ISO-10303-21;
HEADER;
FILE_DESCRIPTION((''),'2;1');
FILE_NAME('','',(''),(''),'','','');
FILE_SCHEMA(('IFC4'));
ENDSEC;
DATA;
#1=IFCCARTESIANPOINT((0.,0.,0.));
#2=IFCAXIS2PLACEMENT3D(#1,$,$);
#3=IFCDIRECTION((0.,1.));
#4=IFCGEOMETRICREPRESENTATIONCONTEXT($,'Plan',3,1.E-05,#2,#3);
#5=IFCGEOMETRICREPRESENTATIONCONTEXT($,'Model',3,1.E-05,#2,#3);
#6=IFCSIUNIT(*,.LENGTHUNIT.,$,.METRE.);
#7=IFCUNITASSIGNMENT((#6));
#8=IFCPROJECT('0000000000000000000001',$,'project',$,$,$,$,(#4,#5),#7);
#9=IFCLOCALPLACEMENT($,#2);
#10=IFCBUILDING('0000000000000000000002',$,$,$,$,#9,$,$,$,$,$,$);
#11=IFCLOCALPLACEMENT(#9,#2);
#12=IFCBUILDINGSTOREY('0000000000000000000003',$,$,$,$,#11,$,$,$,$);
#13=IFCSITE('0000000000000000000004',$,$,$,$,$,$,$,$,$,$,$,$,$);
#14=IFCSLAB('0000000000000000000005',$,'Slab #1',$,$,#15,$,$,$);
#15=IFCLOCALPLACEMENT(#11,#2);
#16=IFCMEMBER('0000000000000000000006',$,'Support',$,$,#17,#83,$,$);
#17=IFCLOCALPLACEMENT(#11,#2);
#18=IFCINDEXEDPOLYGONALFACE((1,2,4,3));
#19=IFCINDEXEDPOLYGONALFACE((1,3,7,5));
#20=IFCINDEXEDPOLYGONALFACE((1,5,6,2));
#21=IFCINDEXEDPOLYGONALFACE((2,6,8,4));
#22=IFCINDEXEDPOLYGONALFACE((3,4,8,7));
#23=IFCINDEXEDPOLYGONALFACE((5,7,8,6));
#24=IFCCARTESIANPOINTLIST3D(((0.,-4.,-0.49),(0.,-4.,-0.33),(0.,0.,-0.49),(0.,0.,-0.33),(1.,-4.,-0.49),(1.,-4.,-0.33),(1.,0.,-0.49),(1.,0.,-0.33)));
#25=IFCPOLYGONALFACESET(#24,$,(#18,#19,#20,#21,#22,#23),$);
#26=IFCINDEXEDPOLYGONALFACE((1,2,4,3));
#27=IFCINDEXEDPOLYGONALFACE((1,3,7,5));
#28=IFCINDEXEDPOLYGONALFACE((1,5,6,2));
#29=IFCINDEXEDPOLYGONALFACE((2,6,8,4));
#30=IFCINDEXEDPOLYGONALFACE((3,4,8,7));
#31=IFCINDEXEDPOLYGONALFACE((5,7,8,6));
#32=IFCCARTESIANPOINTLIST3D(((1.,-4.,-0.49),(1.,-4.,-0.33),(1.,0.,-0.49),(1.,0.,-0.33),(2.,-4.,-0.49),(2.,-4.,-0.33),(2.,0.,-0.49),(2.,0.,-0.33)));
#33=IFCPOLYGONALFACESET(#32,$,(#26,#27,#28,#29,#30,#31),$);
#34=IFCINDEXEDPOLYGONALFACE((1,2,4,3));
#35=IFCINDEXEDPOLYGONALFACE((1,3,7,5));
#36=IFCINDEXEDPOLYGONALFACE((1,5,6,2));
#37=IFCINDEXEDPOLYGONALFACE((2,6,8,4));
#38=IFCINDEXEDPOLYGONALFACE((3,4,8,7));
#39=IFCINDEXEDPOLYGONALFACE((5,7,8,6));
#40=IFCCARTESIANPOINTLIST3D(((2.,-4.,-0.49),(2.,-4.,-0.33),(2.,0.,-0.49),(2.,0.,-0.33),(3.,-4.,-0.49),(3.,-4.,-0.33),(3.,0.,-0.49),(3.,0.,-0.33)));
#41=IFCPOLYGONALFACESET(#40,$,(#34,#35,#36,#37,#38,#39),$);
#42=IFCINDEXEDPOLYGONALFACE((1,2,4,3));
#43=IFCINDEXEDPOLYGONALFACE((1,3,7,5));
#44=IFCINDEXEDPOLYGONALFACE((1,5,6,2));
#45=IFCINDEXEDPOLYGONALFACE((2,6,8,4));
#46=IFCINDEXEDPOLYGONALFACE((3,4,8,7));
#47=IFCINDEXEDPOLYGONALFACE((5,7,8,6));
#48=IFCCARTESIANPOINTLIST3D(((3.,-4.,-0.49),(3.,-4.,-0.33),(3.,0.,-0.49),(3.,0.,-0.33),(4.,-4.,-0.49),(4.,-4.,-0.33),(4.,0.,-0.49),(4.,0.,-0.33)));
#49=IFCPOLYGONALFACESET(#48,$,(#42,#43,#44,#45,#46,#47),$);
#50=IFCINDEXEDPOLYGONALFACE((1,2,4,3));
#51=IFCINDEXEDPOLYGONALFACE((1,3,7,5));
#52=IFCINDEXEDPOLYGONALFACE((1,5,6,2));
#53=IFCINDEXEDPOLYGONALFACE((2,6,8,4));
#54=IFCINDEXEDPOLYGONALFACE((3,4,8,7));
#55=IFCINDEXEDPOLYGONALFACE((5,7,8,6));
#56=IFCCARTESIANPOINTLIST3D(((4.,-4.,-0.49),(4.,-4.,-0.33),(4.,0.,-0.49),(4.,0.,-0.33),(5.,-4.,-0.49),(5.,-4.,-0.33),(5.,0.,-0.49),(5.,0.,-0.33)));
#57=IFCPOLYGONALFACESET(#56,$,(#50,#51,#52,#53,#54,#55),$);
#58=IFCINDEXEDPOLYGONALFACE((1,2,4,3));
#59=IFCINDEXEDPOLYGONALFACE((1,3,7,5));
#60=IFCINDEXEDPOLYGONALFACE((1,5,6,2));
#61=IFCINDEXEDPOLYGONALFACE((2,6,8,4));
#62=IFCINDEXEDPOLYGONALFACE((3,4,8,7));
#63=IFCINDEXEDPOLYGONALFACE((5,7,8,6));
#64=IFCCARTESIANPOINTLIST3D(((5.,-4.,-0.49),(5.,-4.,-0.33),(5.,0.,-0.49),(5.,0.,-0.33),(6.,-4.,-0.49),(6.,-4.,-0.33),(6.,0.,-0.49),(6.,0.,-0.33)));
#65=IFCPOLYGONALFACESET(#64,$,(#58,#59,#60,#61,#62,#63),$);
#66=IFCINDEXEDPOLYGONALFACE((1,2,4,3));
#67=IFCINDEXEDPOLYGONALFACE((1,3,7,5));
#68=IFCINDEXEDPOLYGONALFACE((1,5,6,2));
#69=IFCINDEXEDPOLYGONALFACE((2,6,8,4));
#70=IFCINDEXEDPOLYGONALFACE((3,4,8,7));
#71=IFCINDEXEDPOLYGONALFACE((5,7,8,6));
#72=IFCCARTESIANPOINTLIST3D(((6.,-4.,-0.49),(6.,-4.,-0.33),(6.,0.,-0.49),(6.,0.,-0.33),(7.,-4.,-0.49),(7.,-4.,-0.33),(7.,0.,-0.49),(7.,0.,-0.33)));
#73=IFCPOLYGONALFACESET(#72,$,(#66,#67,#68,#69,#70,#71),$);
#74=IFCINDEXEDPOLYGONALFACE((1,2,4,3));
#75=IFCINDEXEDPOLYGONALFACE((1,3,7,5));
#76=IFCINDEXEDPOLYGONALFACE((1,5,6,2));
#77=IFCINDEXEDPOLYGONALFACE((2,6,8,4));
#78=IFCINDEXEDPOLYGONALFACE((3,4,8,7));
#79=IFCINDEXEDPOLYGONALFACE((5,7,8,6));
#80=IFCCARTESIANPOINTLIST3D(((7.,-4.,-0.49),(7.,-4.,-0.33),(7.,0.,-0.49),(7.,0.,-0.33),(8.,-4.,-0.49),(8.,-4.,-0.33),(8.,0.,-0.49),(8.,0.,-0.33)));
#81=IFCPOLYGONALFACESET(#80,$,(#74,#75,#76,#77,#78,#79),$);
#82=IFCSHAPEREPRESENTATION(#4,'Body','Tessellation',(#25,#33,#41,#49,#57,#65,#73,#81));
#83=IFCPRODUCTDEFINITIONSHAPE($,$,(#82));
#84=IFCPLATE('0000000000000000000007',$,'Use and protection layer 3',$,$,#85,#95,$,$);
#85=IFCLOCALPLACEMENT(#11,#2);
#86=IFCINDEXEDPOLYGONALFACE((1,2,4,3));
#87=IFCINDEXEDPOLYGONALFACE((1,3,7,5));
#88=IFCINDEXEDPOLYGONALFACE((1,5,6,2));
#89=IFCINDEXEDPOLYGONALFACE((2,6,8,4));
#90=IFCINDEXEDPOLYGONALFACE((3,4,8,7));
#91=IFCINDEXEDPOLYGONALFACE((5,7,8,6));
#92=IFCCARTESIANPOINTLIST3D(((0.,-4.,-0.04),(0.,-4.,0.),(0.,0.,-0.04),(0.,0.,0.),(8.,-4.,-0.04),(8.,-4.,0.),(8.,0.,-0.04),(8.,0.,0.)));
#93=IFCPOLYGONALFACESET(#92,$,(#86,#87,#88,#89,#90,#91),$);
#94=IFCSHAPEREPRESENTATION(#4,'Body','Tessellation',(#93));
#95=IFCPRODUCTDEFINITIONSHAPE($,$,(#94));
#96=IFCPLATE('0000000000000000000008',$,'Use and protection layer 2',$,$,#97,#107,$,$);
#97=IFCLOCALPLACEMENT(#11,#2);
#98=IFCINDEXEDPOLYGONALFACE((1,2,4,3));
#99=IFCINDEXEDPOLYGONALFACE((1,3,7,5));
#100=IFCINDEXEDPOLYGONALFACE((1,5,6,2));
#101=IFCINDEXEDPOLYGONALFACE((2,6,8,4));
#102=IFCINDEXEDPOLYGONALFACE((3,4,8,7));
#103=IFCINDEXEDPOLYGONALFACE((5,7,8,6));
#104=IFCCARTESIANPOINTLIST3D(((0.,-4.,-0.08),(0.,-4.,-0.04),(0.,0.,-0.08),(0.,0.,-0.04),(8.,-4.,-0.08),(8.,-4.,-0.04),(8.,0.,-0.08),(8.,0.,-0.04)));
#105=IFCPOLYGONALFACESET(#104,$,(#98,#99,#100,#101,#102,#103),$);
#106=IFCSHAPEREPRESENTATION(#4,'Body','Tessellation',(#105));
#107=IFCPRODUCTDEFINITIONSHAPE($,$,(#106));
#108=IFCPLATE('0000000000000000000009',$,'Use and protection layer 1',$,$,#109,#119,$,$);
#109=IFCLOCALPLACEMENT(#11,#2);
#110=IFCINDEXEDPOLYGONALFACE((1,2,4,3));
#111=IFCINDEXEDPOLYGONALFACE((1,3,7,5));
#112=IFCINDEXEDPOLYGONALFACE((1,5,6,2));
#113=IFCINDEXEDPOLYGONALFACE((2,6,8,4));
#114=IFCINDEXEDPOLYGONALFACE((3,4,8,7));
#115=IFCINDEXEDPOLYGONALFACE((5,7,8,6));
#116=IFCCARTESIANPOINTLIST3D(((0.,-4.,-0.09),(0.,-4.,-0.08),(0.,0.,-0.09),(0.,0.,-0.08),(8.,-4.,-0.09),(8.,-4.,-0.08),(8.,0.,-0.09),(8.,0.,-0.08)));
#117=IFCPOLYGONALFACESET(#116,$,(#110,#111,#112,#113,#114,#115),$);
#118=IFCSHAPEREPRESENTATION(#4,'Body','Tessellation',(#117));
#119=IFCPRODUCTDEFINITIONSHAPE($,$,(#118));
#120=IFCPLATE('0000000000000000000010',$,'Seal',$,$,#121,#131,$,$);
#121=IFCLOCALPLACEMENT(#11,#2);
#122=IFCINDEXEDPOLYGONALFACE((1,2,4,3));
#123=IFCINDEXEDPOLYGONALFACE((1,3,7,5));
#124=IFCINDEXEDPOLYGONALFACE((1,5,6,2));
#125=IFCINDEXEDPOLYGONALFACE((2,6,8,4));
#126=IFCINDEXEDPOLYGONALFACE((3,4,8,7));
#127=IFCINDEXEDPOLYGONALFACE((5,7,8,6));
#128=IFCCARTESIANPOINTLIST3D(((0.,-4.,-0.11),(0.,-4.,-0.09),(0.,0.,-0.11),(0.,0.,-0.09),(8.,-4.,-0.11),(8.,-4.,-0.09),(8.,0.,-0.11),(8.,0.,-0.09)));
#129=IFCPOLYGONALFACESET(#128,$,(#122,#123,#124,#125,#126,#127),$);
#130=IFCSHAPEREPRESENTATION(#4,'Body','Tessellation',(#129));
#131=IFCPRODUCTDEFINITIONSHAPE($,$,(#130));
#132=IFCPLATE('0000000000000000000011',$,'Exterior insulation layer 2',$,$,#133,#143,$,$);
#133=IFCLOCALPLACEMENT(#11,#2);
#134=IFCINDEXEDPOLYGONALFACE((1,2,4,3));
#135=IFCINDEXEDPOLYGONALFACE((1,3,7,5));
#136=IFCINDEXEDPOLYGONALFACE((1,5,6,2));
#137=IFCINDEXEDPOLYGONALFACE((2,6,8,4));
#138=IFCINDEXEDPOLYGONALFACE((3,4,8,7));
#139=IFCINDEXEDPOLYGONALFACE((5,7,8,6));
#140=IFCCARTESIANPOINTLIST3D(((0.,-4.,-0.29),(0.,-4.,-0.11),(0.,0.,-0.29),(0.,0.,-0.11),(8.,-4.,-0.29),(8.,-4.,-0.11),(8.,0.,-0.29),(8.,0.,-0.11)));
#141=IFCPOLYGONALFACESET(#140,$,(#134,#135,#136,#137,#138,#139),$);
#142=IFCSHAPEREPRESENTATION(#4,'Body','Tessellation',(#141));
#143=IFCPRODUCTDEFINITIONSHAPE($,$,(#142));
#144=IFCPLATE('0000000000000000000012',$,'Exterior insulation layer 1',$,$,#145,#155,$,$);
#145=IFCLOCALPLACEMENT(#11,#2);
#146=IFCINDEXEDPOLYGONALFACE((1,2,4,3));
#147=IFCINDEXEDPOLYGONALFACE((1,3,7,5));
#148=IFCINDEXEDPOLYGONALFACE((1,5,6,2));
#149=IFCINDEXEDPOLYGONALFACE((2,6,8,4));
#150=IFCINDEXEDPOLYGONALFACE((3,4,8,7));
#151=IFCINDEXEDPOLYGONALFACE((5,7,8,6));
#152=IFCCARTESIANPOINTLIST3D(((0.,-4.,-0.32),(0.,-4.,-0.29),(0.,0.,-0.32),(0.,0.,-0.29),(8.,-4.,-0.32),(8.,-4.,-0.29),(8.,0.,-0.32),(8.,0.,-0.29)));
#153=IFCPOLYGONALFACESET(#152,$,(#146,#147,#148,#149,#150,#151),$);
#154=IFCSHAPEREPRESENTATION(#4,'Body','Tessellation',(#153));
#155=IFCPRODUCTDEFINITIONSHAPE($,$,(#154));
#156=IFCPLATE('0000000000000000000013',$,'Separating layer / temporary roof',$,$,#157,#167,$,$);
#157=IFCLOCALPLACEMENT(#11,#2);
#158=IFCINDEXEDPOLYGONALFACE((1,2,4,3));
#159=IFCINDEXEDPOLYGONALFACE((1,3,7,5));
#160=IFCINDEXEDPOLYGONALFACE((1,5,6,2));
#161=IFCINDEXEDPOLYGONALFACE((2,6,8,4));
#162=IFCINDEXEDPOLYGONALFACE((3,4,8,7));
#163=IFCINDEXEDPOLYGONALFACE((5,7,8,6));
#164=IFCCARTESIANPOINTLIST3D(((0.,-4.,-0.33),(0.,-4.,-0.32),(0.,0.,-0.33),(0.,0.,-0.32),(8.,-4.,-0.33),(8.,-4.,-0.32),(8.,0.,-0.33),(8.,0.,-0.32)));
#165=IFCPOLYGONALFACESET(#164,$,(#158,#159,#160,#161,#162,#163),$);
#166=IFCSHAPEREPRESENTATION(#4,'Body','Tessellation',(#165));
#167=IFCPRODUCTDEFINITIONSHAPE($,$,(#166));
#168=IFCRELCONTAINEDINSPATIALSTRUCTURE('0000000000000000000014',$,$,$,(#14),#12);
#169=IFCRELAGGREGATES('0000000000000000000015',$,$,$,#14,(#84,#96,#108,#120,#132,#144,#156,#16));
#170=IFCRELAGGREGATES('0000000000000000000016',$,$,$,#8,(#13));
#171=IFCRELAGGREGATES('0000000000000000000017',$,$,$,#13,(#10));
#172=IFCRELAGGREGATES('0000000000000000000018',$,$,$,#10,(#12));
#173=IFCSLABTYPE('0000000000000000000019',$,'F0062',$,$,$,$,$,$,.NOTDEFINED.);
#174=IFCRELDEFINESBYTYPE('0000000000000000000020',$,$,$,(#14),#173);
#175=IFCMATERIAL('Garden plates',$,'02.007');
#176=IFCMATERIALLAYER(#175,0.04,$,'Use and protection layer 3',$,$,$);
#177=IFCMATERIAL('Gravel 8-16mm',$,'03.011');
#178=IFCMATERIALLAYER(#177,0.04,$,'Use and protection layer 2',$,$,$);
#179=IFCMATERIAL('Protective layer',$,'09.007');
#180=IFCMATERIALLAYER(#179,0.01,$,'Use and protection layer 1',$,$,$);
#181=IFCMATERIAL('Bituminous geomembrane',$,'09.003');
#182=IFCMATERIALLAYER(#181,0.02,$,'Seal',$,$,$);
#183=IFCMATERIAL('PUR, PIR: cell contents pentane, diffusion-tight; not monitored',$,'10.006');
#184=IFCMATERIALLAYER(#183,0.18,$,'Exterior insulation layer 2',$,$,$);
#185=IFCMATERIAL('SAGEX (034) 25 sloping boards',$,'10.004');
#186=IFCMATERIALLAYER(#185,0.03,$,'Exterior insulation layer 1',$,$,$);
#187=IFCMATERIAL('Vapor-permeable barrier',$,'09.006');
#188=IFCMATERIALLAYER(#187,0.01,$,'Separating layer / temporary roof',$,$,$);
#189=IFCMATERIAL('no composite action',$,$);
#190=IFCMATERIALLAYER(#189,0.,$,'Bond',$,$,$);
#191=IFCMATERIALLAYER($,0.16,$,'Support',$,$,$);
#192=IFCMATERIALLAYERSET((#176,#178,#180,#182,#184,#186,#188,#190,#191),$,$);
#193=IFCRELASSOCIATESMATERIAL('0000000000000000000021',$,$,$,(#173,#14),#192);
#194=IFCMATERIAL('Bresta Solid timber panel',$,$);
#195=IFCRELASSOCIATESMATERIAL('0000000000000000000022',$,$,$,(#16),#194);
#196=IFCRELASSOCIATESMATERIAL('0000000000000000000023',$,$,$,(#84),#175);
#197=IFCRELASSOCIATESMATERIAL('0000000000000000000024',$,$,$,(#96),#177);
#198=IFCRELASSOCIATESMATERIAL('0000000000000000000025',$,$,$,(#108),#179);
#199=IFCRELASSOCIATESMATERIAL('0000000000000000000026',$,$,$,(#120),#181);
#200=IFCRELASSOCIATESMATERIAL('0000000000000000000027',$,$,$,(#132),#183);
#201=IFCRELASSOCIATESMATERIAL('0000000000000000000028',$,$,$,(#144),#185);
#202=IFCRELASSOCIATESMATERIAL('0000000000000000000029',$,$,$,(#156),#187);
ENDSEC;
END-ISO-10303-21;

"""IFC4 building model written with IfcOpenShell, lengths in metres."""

from ifc_helpers import new_model, si_unit, direction, frame, frame_2d, origin, origin_with_axes, place, context, project, spatial, rectangle, extrude, material, layer, layer_set, type_object, element, aggregate, save


model = new_model("IFC4")

# Units and contexts
plan_context = context("Plan", 3, precision=1e-05, world=origin(), true_north=direction((0.0, 1.0)))
model_context = context("Model", 3, precision=1e-05, world=origin(), true_north=direction((0.0, 1.0)))
ifc_project = project(units=[si_unit("LENGTHUNIT", "METRE")], contexts=[plan_context, model_context])

# Site, building, storey
site = spatial("IfcSite", under=ifc_project)
building_placement = place(None, origin())
building = spatial("IfcBuilding", under=site, at=building_placement)
storey_placement = place(building_placement, origin())
storey = spatial("IfcBuildingStorey", under=building, at=storey_placement)

# Slab, member, plates
ifc_material_1 = material(Name="Garden plates", Category="02.007")
ifc_layer_1 = layer(ifc_material_1, 0.04, Name="Use and protection layer 3")
ifc_material_2 = material(Name="Gravel 8-16mm", Category="03.011")
ifc_layer_2 = layer(ifc_material_2, 0.04, Name="Use and protection layer 2")
ifc_material_3 = material(Name="Protective layer", Category="09.007")
ifc_layer_3 = layer(ifc_material_3, 0.01, Name="Use and protection layer 1")
ifc_material_4 = material(Name="Bituminous geomembrane", Category="09.003")
ifc_layer_4 = layer(ifc_material_4, 0.02, Name="Seal")
ifc_material_5 = material(Name="PUR, PIR: cell contents pentane, diffusion-tight; not monitored", Category="10.006")
ifc_layer_5 = layer(ifc_material_5, 0.18, Name="Exterior insulation layer 2")
ifc_material_6 = material(Name="SAGEX (034) 25 sloping boards", Category="10.004")
ifc_layer_6 = layer(ifc_material_6, 0.03, Name="Exterior insulation layer 1")
ifc_material_7 = material(Name="Vapor-permeable barrier", Category="09.006")
ifc_layer_7 = layer(ifc_material_7, 0.01, Name="Separating layer / temporary roof")
ifc_material_8 = material(Name="no composite action")
ifc_layer_8 = layer(ifc_material_8, 0.0, Name="Bond")
ifc_layer_9 = layer(None, 0.16, Name="Support")
ifc_layer_set = layer_set([ifc_layer_1, ifc_layer_2, ifc_layer_3, ifc_layer_4, ifc_layer_5, ifc_layer_6, ifc_layer_7, ifc_layer_8, ifc_layer_9])
slab_type = type_object("IfcSlabType", Name="F0062", PredefinedType="NOTDEFINED", material=ifc_layer_set)
slab_placement = place(None, frame((0.0, 0.0, 0.0), z_axis=(0.0, 0.0, -1.0), x_axis=(1.0, 0.0, 0.0)))
slab = element("IfcSlab", 1, at=slab_placement, inside=storey, type_object=slab_type, material=ifc_layer_set, Name="Slab #1")
ifc_material_9 = material(Name="Bresta Solid timber panel")
member_placement = place(slab_placement, origin())
member = element("IfcMember", 2, at=member_placement, material=ifc_material_9, Name="Support", context=plan_context, shape_type="SweptSolid", body=[
    extrude(rectangle(XDim=1.0, YDim=0.16, at=frame_2d((0.5, 0.08), x_axis=(1.0, 0.0))), frame((0.0, 4.0, 0.33), z_axis=(0.0, -1.0, 0.0), x_axis=(1.0, 0.0, 0.0)), (0.0, 0.0, 1.0), 4.0),
    extrude(rectangle(XDim=1.0, YDim=0.16, at=frame_2d((0.5, 0.08), x_axis=(1.0, 0.0))), frame((1.0, 4.0, 0.33), z_axis=(0.0, -1.0, 0.0), x_axis=(1.0, 0.0, 0.0)), (0.0, 0.0, 1.0), 4.0),
    extrude(rectangle(XDim=1.0, YDim=0.16, at=frame_2d((0.5, 0.08), x_axis=(1.0, 0.0))), frame((2.0, 4.0, 0.33), z_axis=(0.0, -1.0, 0.0), x_axis=(1.0, 0.0, 0.0)), (0.0, 0.0, 1.0), 4.0),
    extrude(rectangle(XDim=1.0, YDim=0.16, at=frame_2d((0.5, 0.08), x_axis=(1.0, 0.0))), frame((3.0, 4.0, 0.33), z_axis=(0.0, -1.0, 0.0), x_axis=(1.0, 0.0, 0.0)), (0.0, 0.0, 1.0), 4.0),
    extrude(rectangle(XDim=1.0, YDim=0.16, at=frame_2d((0.5, 0.08), x_axis=(1.0, 0.0))), frame((4.0, 4.0, 0.33), z_axis=(0.0, -1.0, 0.0), x_axis=(1.0, 0.0, 0.0)), (0.0, 0.0, 1.0), 4.0),
    extrude(rectangle(XDim=1.0, YDim=0.16, at=frame_2d((0.5, 0.08), x_axis=(1.0, 0.0))), frame((5.0, 4.0, 0.33), z_axis=(0.0, -1.0, 0.0), x_axis=(1.0, 0.0, 0.0)), (0.0, 0.0, 1.0), 4.0),
    extrude(rectangle(XDim=1.0, YDim=0.16, at=frame_2d((0.5, 0.08), x_axis=(1.0, 0.0))), frame((6.0, 4.0, 0.33), z_axis=(0.0, -1.0, 0.0), x_axis=(1.0, 0.0, 0.0)), (0.0, 0.0, 1.0), 4.0),
    extrude(rectangle(XDim=1.0, YDim=0.16, at=frame_2d((0.5, 0.08), x_axis=(1.0, 0.0))), frame((7.0, 4.0, 0.33), z_axis=(0.0, -1.0, 0.0), x_axis=(1.0, 0.0, 0.0)), (0.0, 0.0, 1.0), 4.0),
])
plate_1_placement = place(slab_placement, origin())
plate_1 = element("IfcPlate", 3, at=plate_1_placement, material=ifc_material_1, Name="Use and protection layer 3", context=plan_context, shape_type="SweptSolid", body=[
    extrude(rectangle(XDim=8.0, YDim=4.0, at=frame_2d((4.0, 2.0), x_axis=(1.0, 0.0))), origin_with_axes(), (0.0, 0.0, 1.0), 0.04),
])
plate_2_placement = place(slab_placement, origin())
plate_2 = element("IfcPlate", 4, at=plate_2_placement, material=ifc_material_2, Name="Use and protection layer 2", context=plan_context, shape_type="SweptSolid", body=[
    extrude(rectangle(XDim=8.0, YDim=4.0, at=frame_2d((4.0, 2.0), x_axis=(1.0, 0.0))), frame((0.0, 0.0, 0.04), z_axis=(0.0, 0.0, 1.0), x_axis=(1.0, 0.0, 0.0)), (0.0, 0.0, 1.0), 0.04),
])
plate_3_placement = place(slab_placement, origin())
plate_3 = element("IfcPlate", 5, at=plate_3_placement, material=ifc_material_3, Name="Use and protection layer 1", context=plan_context, shape_type="SweptSolid", body=[
    extrude(rectangle(XDim=8.0, YDim=4.0, at=frame_2d((4.0, 2.0), x_axis=(1.0, 0.0))), frame((0.0, 0.0, 0.08), z_axis=(0.0, 0.0, 1.0), x_axis=(1.0, 0.0, 0.0)), (0.0, 0.0, 1.0), 0.01),
])
plate_4_placement = place(slab_placement, origin())
plate_4 = element("IfcPlate", 6, at=plate_4_placement, material=ifc_material_4, Name="Seal", context=plan_context, shape_type="SweptSolid", body=[
    extrude(rectangle(XDim=8.0, YDim=4.0, at=frame_2d((4.0, 2.0), x_axis=(1.0, 0.0))), frame((0.0, 0.0, 0.09), z_axis=(0.0, 0.0, 1.0), x_axis=(1.0, 0.0, 0.0)), (0.0, 0.0, 1.0), 0.02),
])
plate_5_placement = place(slab_placement, origin())
plate_5 = element("IfcPlate", 7, at=plate_5_placement, material=ifc_material_5, Name="Exterior insulation layer 2", context=plan_context, shape_type="SweptSolid", body=[
    extrude(rectangle(XDim=8.0, YDim=4.0, at=frame_2d((4.0, 2.0), x_axis=(1.0, 0.0))), frame((0.0, 0.0, 0.11), z_axis=(0.0, 0.0, 1.0), x_axis=(1.0, 0.0, 0.0)), (0.0, 0.0, 1.0), 0.18),
])
plate_6_placement = place(slab_placement, origin())
plate_6 = element("IfcPlate", 8, at=plate_6_placement, material=ifc_material_6, Name="Exterior insulation layer 1", context=plan_context, shape_type="SweptSolid", body=[
    extrude(rectangle(XDim=8.0, YDim=4.0, at=frame_2d((4.0, 2.0), x_axis=(1.0, 0.0))), frame((0.0, 0.0, 0.29), z_axis=(0.0, 0.0, 1.0), x_axis=(1.0, 0.0, 0.0)), (0.0, 0.0, 1.0), 0.03),
])
plate_7_placement = place(slab_placement, origin())
plate_7 = element("IfcPlate", 9, at=plate_7_placement, material=ifc_material_7, Name="Separating layer / temporary roof", context=plan_context, shape_type="SweptSolid", body=[
    extrude(rectangle(XDim=8.0, YDim=4.0, at=frame_2d((4.0, 2.0), x_axis=(1.0, 0.0))), frame((0.0, 0.0, 0.32), z_axis=(0.0, 0.0, 1.0), x_axis=(1.0, 0.0, 0.0)), (0.0, 0.0, 1.0), 0.01),
])
aggregate(slab, [plate_1, plate_2, plate_3, plate_4, plate_5, plate_6, plate_7, member])

save(model, "model.ifc")
